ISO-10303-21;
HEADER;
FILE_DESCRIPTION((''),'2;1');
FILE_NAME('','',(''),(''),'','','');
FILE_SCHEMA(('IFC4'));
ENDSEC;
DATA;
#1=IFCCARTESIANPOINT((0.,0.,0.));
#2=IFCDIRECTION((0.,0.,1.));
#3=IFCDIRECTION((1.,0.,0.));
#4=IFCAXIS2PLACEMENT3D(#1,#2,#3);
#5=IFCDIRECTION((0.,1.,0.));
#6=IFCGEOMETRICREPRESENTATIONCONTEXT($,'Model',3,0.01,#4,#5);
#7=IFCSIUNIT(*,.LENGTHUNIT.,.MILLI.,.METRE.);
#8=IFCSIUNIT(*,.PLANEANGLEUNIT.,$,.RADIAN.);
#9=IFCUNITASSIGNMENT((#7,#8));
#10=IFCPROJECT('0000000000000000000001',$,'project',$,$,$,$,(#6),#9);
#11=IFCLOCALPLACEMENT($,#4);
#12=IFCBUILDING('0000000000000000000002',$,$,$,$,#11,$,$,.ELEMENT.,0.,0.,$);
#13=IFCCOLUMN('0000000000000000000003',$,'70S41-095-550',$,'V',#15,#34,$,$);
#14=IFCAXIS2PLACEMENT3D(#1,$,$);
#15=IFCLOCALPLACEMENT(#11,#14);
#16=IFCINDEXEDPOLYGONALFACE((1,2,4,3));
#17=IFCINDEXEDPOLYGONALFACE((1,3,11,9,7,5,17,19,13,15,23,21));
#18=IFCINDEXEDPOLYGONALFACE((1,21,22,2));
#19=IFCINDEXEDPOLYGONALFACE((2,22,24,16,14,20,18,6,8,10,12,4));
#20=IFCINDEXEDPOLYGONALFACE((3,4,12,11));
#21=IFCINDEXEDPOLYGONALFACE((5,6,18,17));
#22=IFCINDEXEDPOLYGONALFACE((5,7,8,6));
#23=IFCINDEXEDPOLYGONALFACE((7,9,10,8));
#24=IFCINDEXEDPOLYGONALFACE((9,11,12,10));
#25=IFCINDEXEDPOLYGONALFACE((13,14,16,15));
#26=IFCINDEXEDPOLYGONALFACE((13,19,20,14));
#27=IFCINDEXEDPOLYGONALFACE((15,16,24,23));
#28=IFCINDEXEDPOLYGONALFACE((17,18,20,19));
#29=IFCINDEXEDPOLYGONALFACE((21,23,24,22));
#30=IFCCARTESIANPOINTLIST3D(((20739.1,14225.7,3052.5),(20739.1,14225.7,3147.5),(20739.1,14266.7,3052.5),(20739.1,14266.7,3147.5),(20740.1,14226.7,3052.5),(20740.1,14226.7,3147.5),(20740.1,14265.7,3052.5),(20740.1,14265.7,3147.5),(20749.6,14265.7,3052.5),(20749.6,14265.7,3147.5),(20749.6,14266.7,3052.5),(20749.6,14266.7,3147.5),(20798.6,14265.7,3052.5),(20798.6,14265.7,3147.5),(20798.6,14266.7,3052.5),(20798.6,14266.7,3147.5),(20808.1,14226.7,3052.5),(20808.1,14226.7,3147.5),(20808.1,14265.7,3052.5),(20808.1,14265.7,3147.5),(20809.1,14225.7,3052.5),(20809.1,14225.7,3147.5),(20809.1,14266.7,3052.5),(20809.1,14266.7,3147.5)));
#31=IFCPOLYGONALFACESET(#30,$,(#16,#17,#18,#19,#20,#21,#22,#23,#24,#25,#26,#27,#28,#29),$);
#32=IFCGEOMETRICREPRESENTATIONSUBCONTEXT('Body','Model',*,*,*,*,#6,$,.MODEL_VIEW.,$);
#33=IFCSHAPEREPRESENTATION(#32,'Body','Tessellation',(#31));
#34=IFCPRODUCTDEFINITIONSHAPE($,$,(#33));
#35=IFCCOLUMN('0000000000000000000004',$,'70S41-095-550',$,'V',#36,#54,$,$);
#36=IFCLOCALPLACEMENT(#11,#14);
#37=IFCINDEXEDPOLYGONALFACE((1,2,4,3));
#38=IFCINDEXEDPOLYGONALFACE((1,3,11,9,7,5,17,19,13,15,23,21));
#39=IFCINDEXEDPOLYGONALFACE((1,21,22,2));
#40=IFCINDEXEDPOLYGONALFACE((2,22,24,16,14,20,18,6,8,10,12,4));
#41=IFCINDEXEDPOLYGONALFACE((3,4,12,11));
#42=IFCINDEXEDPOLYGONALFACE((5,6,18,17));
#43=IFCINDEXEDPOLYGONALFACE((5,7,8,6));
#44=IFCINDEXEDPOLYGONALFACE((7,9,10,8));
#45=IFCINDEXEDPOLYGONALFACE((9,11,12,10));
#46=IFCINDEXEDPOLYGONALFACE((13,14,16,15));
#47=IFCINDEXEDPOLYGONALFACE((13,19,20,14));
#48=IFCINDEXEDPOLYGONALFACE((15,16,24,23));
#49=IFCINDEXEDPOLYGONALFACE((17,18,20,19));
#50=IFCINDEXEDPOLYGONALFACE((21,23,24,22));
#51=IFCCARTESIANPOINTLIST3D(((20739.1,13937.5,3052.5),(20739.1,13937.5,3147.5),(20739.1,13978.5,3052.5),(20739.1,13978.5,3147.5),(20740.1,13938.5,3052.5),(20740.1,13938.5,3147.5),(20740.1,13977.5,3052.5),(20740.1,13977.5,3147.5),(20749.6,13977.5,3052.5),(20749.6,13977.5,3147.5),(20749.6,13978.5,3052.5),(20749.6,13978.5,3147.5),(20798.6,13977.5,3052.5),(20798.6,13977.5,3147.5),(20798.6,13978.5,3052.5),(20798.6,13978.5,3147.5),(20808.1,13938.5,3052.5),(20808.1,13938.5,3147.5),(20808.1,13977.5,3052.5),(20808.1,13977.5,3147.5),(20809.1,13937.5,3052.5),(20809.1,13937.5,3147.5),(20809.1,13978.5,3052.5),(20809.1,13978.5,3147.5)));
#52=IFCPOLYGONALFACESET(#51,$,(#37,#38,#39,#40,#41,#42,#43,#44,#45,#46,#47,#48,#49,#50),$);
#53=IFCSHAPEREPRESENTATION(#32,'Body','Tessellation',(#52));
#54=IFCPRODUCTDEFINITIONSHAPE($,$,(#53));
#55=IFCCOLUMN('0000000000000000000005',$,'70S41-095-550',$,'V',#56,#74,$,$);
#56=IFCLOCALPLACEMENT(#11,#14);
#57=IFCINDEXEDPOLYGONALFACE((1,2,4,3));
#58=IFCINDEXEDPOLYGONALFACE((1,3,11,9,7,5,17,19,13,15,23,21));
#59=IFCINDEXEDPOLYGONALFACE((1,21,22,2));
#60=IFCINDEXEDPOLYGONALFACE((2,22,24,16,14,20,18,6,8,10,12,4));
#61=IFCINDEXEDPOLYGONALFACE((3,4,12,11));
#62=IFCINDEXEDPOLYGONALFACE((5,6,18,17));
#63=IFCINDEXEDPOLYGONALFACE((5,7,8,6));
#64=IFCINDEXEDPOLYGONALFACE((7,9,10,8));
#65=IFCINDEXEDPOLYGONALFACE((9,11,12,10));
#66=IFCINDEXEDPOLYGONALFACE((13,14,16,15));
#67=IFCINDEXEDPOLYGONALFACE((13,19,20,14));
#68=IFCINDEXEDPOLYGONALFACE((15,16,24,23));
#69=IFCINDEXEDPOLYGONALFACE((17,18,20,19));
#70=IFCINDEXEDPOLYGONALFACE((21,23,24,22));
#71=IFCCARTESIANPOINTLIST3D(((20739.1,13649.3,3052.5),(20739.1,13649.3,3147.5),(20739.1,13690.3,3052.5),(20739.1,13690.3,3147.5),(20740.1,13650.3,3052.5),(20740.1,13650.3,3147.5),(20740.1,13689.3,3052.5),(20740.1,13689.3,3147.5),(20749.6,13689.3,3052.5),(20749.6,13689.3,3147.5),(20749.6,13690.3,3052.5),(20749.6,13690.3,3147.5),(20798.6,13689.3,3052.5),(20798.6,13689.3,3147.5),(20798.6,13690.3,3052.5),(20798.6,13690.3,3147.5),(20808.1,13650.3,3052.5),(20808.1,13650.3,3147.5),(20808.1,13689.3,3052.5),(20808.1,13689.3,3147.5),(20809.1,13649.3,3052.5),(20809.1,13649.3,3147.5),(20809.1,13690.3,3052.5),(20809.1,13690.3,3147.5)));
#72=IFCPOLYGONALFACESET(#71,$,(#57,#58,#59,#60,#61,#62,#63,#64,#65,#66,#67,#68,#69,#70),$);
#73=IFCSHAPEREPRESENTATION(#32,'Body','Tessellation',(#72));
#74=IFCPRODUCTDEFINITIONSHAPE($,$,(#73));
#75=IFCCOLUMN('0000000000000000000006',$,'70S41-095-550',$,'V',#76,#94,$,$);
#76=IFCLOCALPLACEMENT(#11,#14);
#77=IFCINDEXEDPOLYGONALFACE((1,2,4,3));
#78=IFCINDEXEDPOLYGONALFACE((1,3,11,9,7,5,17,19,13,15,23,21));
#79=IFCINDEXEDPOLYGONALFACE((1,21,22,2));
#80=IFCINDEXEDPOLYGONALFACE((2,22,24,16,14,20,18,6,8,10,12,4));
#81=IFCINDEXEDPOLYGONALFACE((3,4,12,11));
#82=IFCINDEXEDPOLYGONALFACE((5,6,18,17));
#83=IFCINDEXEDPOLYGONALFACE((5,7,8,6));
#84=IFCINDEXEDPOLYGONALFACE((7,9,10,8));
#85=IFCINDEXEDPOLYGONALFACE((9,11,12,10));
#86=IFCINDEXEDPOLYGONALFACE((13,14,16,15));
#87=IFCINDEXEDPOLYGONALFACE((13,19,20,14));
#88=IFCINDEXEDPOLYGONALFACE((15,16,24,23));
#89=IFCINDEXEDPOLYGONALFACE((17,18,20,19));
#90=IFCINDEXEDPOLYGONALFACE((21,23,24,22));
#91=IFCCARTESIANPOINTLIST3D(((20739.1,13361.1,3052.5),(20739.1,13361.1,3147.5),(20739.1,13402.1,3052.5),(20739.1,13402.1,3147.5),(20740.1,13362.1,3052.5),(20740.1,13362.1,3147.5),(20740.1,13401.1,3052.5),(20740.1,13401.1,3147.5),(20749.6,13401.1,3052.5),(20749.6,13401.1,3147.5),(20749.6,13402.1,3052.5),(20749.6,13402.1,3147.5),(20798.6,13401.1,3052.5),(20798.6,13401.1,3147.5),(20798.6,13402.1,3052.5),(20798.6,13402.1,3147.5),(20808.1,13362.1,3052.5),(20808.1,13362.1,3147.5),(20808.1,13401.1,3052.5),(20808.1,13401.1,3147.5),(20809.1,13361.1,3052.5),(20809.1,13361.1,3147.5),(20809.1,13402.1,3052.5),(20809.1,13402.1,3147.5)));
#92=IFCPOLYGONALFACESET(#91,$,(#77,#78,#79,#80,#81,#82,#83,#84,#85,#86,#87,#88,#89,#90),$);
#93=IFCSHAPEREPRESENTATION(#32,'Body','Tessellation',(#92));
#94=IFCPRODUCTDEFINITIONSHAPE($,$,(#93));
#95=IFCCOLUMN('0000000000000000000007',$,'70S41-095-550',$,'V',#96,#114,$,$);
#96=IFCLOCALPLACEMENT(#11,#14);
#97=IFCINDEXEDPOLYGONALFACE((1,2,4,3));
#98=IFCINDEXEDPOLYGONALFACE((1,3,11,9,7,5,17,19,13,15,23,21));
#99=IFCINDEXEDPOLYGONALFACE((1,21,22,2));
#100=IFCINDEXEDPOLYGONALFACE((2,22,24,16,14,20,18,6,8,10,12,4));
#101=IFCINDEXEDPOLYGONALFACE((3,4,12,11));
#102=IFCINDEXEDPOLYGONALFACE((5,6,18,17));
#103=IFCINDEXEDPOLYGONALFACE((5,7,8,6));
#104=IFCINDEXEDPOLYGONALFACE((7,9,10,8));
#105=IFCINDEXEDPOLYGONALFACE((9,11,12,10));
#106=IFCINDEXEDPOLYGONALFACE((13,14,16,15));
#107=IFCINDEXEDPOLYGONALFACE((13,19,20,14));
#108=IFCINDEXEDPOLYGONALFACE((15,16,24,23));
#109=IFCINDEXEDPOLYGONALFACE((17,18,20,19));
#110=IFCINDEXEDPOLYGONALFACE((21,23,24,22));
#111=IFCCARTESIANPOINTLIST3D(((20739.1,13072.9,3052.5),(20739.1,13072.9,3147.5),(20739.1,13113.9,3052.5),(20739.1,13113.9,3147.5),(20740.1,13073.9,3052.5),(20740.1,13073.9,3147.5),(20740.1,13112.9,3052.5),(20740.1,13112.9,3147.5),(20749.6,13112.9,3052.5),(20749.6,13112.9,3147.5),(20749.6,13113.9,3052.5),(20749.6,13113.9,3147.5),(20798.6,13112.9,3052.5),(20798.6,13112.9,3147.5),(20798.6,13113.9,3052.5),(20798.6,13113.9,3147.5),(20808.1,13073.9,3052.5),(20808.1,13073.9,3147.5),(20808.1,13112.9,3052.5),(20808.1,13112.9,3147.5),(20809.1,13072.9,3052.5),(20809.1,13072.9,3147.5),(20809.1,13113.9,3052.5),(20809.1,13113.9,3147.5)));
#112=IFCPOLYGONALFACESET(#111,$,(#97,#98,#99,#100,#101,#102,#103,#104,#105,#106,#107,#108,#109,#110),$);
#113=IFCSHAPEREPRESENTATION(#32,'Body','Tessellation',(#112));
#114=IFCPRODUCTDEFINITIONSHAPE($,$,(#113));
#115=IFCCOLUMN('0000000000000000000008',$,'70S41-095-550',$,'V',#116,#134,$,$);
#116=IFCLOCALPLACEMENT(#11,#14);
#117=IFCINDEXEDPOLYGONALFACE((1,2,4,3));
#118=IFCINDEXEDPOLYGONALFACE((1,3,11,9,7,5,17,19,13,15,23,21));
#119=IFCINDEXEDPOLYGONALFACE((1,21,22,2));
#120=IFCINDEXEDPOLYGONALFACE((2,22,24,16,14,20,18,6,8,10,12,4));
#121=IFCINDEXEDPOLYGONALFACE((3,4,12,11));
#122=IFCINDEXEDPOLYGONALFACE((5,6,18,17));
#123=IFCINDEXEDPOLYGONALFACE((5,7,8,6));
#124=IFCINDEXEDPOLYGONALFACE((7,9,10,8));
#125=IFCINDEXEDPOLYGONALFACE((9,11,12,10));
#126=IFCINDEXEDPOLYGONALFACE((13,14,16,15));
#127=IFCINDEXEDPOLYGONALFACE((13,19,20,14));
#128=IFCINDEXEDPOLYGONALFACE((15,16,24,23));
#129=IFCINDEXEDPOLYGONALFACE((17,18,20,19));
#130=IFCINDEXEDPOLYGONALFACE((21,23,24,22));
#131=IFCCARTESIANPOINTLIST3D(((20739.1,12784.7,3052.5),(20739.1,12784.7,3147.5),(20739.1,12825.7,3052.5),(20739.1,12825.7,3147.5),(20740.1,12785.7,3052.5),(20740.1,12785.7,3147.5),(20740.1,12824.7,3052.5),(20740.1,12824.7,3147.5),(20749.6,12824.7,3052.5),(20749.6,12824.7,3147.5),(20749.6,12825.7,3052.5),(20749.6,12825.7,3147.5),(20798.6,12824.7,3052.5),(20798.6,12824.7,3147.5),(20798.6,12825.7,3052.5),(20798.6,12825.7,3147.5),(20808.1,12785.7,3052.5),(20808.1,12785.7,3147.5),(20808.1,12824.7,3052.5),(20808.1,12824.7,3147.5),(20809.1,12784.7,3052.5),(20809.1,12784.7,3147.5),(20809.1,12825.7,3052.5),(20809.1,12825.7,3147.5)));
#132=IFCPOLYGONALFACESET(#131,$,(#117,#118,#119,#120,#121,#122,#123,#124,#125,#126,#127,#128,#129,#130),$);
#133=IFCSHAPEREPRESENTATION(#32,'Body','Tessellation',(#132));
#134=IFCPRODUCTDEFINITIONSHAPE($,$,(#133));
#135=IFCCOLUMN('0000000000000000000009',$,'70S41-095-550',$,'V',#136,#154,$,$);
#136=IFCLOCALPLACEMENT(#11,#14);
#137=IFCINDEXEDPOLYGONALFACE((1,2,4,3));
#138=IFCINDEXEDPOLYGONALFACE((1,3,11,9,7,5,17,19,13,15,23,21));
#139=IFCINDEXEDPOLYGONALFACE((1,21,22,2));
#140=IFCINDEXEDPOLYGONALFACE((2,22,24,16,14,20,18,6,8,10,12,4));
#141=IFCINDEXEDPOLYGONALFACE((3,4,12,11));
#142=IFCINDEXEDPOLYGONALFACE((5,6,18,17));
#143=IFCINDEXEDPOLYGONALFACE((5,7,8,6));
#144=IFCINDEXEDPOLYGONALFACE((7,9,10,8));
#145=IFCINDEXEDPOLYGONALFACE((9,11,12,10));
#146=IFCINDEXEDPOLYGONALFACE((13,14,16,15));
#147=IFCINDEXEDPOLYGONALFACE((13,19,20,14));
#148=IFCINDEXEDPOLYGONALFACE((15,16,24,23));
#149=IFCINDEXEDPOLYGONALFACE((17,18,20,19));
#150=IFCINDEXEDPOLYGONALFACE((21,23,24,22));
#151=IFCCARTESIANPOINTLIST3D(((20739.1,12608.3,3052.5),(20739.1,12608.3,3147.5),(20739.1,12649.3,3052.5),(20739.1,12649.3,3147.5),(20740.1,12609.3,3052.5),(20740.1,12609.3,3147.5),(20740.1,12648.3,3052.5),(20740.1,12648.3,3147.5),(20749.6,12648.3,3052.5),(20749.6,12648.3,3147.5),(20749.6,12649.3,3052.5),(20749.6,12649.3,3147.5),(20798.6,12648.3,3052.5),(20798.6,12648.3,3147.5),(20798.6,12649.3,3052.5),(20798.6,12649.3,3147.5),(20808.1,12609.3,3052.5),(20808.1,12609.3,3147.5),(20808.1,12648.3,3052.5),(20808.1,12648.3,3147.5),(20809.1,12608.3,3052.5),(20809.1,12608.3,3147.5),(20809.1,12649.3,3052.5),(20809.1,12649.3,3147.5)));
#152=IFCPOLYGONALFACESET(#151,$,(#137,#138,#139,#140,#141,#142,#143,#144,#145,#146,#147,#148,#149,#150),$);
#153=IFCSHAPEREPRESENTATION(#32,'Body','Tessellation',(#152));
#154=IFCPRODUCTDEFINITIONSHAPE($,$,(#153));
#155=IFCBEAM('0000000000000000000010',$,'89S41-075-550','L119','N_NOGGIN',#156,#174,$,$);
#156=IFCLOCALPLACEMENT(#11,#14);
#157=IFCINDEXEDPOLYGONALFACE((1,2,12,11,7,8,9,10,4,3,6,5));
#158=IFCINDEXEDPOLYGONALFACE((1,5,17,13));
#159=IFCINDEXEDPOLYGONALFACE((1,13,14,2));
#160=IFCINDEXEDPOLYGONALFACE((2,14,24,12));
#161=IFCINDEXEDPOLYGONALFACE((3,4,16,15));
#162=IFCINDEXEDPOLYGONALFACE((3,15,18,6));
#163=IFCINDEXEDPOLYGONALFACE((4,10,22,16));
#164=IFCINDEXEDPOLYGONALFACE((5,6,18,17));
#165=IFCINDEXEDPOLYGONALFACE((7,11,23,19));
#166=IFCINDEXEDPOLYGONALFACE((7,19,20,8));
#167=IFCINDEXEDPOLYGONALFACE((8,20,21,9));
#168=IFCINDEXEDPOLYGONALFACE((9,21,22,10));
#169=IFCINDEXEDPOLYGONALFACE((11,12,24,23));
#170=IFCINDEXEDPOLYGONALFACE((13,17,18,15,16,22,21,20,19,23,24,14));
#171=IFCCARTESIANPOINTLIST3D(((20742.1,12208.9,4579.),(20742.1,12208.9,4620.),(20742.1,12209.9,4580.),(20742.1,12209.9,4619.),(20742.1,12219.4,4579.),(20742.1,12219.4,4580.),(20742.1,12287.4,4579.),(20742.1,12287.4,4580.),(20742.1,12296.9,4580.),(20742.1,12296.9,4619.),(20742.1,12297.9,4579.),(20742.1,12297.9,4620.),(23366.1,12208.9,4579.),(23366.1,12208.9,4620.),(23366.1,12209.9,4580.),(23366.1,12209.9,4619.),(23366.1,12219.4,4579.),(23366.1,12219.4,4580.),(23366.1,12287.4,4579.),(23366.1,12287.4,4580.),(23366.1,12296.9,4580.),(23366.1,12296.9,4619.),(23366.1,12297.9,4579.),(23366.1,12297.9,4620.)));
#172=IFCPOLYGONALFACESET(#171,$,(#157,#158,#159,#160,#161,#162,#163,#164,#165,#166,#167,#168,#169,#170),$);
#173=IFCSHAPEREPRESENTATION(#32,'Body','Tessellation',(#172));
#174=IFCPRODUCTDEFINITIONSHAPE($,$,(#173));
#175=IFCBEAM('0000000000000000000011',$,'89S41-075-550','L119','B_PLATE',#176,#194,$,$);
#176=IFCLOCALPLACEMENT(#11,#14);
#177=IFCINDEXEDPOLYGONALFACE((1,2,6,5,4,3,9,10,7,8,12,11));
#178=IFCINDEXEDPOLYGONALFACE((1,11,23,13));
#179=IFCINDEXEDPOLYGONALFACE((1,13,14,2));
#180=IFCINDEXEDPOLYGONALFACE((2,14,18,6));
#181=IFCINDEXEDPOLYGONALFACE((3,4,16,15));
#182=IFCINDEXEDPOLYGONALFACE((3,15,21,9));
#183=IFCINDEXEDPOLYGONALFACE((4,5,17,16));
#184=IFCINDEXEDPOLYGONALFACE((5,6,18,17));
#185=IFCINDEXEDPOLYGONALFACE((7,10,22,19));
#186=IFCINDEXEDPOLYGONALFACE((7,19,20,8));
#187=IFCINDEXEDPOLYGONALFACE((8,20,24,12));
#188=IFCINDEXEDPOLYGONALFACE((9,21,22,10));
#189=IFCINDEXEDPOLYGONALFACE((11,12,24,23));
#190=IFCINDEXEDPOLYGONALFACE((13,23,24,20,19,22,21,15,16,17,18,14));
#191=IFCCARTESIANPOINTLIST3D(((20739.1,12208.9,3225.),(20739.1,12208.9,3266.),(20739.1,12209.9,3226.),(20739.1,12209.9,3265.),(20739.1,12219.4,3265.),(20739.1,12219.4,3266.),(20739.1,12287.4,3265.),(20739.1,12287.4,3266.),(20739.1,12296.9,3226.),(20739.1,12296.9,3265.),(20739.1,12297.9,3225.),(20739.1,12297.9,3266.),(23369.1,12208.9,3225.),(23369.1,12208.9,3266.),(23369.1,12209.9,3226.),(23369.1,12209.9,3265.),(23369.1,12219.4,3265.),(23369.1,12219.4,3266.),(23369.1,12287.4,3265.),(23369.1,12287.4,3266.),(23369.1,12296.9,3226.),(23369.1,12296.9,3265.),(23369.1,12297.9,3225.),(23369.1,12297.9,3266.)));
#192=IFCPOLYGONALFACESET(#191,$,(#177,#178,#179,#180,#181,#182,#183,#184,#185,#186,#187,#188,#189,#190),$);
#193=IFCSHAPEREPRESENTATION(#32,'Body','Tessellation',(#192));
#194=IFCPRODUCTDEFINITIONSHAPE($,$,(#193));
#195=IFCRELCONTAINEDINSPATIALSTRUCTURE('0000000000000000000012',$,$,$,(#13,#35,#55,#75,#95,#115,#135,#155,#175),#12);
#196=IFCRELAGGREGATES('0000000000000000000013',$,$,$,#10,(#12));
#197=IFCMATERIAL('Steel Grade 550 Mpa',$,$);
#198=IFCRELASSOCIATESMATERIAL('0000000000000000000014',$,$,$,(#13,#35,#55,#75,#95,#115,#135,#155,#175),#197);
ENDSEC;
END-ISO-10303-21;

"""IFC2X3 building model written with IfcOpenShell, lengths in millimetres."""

from ifc_helpers import new_model, si_unit, direction, frame, origin, origin_with_axes, origin_2d_with_axis, place, context, subcontext, project, spatial, c_section, extrude, source, transform, mapped, material, element, save


model = new_model("IFC2X3")

# Units and contexts
model_context = context("Model", 3, precision=0.01, world=origin_with_axes(), true_north=direction((0.0, 1.0, 0.0)))
body_context = subcontext(model_context, "Body", "Model", "MODEL_VIEW")
ifc_project = project(units=[si_unit("LENGTHUNIT", "METRE", prefix="MILLI"), si_unit("PLANEANGLEUNIT", "RADIAN")], contexts=[model_context])

# Building
building_placement = place(None, origin_with_axes())
building = spatial("IfcBuilding", under=ifc_project, at=building_placement, CompositionType="ELEMENT", ElevationOfRefHeight=0.0, ElevationOfTerrain=0.0)

# Columns
ifc_material = material(Name="Steel Grade 550 Mpa")
shared_shape_1 = source(origin(), body_context, "Body", "SweptSolid", [
    extrude(c_section(Depth=70.0, Width=41.0, WallThickness=1.0, Girth=10.5, at=origin_2d_with_axis()), origin_with_axes(), (0.0, 0.0, 1.0), 95.0),
])
column_1_placement = place(None, frame((20774.1, 14246.2, 3147.5), z_axis=(0.0, 0.0, -1.0), x_axis=(0.0, 1.0, 0.0)))
element("IfcColumn", 1, at=column_1_placement, inside=building, material=ifc_material, Name="70S41-095-550", ObjectType="V", context=body_context, shape_type="MappedRepresentation", body=[
    mapped(shared_shape_1, transform((0.0, 0.0, 0.0), scale=1.0)),
])
shared_shape_2 = source(origin(), body_context, "Body", "SweptSolid", [
    extrude(c_section(Depth=70.0, Width=41.0, WallThickness=1.0, Girth=10.5, at=origin_2d_with_axis()), origin_with_axes(), (0.0, 0.0, 1.0), 95.0),
])
column_2_placement = place(None, frame((20774.1, 13958.0, 3147.5), z_axis=(0.0, 0.0, -1.0), x_axis=(0.0, 1.0, 0.0)))
element("IfcColumn", 2, at=column_2_placement, inside=building, material=ifc_material, Name="70S41-095-550", ObjectType="V", context=body_context, shape_type="MappedRepresentation", body=[
    mapped(shared_shape_2, transform((0.0, 0.0, 0.0), scale=1.0)),
])
shared_shape_3 = source(origin(), body_context, "Body", "SweptSolid", [
    extrude(c_section(Depth=70.0, Width=41.0, WallThickness=1.0, Girth=10.5, at=origin_2d_with_axis()), origin_with_axes(), (0.0, 0.0, 1.0), 95.0),
])
column_3_placement = place(None, frame((20774.1, 13669.8, 3147.5), z_axis=(0.0, 0.0, -1.0), x_axis=(0.0, 1.0, 0.0)))
element("IfcColumn", 3, at=column_3_placement, inside=building, material=ifc_material, Name="70S41-095-550", ObjectType="V", context=body_context, shape_type="MappedRepresentation", body=[
    mapped(shared_shape_3, transform((0.0, 0.0, 0.0), scale=1.0)),
])
shared_shape_4 = source(origin(), body_context, "Body", "SweptSolid", [
    extrude(c_section(Depth=70.0, Width=41.0, WallThickness=1.0, Girth=10.5, at=origin_2d_with_axis()), origin_with_axes(), (0.0, 0.0, 1.0), 95.0),
])
column_4_placement = place(None, frame((20774.1, 13381.6, 3147.5), z_axis=(0.0, 0.0, -1.0), x_axis=(0.0, 1.0, 0.0)))
element("IfcColumn", 4, at=column_4_placement, inside=building, material=ifc_material, Name="70S41-095-550", ObjectType="V", context=body_context, shape_type="MappedRepresentation", body=[
    mapped(shared_shape_4, transform((0.0, 0.0, 0.0), scale=1.0)),
])
shared_shape_5 = source(origin(), body_context, "Body", "SweptSolid", [
    extrude(c_section(Depth=70.0, Width=41.0, WallThickness=1.0, Girth=10.5, at=origin_2d_with_axis()), origin_with_axes(), (0.0, 0.0, 1.0), 95.0),
])
column_5_placement = place(None, frame((20774.1, 13093.4, 3147.5), z_axis=(0.0, 0.0, -1.0), x_axis=(0.0, 1.0, 0.0)))
element("IfcColumn", 5, at=column_5_placement, inside=building, material=ifc_material, Name="70S41-095-550", ObjectType="V", context=body_context, shape_type="MappedRepresentation", body=[
    mapped(shared_shape_5, transform((0.0, 0.0, 0.0), scale=1.0)),
])
shared_shape_6 = source(origin(), body_context, "Body", "SweptSolid", [
    extrude(c_section(Depth=70.0, Width=41.0, WallThickness=1.0, Girth=10.5, at=origin_2d_with_axis()), origin_with_axes(), (0.0, 0.0, 1.0), 95.0),
])
column_6_placement = place(None, frame((20774.1, 12805.2, 3147.5), z_axis=(0.0, 0.0, -1.0), x_axis=(0.0, 1.0, 0.0)))
element("IfcColumn", 6, at=column_6_placement, inside=building, material=ifc_material, Name="70S41-095-550", ObjectType="V", context=body_context, shape_type="MappedRepresentation", body=[
    mapped(shared_shape_6, transform((0.0, 0.0, 0.0), scale=1.0)),
])
shared_shape_7 = source(origin(), body_context, "Body", "SweptSolid", [
    extrude(c_section(Depth=70.0, Width=41.0, WallThickness=1.0, Girth=10.5, at=origin_2d_with_axis()), origin_with_axes(), (0.0, 0.0, 1.0), 95.0),
])
column_7_placement = place(None, frame((20774.1, 12628.8, 3147.5), z_axis=(0.0, 0.0, -1.0), x_axis=(0.0, 1.0, 0.0)))
element("IfcColumn", 7, at=column_7_placement, inside=building, material=ifc_material, Name="70S41-095-550", ObjectType="V", context=body_context, shape_type="MappedRepresentation", body=[
    mapped(shared_shape_7, transform((0.0, 0.0, 0.0), scale=1.0)),
])

# Beams
shared_shape_8 = source(origin(), body_context, "Body", "SweptSolid", [
    extrude(c_section(Depth=89.0, Width=41.0, WallThickness=1.0, Girth=10.5, at=origin_2d_with_axis()), origin_with_axes(), (0.0, 0.0, 1.0), 2624.0),
])
beam_1_placement = place(None, frame((20742.1, 12253.4, 4599.5), z_axis=(1.0, 0.0, 0.0), x_axis=(0.0, 0.0, -1.0)))
element("IfcBeam", 8, at=beam_1_placement, inside=building, material=ifc_material, Name="89S41-075-550", Description="L119", ObjectType="N_NOGGIN", context=body_context, shape_type="MappedRepresentation", body=[
    mapped(shared_shape_8, transform((0.0, 0.0, 0.0), scale=1.0)),
])
shared_shape_9 = source(origin(), body_context, "Body", "SweptSolid", [
    extrude(c_section(Depth=89.0, Width=41.0, WallThickness=1.0, Girth=10.5, at=origin_2d_with_axis()), origin_with_axes(), (0.0, 0.0, 1.0), 2630.0),
])
beam_2_placement = place(None, frame((20739.1, 12253.4, 3245.5), z_axis=(1.0, 0.0, 0.0), x_axis=(0.0, 0.0, 1.0)))
element("IfcBeam", 9, at=beam_2_placement, inside=building, material=ifc_material, Name="89S41-075-550", Description="L119", ObjectType="B_PLATE", context=body_context, shape_type="MappedRepresentation", body=[
    mapped(shared_shape_9, transform((0.0, 0.0, 0.0), scale=1.0)),
])

save(model, "model.ifc")
